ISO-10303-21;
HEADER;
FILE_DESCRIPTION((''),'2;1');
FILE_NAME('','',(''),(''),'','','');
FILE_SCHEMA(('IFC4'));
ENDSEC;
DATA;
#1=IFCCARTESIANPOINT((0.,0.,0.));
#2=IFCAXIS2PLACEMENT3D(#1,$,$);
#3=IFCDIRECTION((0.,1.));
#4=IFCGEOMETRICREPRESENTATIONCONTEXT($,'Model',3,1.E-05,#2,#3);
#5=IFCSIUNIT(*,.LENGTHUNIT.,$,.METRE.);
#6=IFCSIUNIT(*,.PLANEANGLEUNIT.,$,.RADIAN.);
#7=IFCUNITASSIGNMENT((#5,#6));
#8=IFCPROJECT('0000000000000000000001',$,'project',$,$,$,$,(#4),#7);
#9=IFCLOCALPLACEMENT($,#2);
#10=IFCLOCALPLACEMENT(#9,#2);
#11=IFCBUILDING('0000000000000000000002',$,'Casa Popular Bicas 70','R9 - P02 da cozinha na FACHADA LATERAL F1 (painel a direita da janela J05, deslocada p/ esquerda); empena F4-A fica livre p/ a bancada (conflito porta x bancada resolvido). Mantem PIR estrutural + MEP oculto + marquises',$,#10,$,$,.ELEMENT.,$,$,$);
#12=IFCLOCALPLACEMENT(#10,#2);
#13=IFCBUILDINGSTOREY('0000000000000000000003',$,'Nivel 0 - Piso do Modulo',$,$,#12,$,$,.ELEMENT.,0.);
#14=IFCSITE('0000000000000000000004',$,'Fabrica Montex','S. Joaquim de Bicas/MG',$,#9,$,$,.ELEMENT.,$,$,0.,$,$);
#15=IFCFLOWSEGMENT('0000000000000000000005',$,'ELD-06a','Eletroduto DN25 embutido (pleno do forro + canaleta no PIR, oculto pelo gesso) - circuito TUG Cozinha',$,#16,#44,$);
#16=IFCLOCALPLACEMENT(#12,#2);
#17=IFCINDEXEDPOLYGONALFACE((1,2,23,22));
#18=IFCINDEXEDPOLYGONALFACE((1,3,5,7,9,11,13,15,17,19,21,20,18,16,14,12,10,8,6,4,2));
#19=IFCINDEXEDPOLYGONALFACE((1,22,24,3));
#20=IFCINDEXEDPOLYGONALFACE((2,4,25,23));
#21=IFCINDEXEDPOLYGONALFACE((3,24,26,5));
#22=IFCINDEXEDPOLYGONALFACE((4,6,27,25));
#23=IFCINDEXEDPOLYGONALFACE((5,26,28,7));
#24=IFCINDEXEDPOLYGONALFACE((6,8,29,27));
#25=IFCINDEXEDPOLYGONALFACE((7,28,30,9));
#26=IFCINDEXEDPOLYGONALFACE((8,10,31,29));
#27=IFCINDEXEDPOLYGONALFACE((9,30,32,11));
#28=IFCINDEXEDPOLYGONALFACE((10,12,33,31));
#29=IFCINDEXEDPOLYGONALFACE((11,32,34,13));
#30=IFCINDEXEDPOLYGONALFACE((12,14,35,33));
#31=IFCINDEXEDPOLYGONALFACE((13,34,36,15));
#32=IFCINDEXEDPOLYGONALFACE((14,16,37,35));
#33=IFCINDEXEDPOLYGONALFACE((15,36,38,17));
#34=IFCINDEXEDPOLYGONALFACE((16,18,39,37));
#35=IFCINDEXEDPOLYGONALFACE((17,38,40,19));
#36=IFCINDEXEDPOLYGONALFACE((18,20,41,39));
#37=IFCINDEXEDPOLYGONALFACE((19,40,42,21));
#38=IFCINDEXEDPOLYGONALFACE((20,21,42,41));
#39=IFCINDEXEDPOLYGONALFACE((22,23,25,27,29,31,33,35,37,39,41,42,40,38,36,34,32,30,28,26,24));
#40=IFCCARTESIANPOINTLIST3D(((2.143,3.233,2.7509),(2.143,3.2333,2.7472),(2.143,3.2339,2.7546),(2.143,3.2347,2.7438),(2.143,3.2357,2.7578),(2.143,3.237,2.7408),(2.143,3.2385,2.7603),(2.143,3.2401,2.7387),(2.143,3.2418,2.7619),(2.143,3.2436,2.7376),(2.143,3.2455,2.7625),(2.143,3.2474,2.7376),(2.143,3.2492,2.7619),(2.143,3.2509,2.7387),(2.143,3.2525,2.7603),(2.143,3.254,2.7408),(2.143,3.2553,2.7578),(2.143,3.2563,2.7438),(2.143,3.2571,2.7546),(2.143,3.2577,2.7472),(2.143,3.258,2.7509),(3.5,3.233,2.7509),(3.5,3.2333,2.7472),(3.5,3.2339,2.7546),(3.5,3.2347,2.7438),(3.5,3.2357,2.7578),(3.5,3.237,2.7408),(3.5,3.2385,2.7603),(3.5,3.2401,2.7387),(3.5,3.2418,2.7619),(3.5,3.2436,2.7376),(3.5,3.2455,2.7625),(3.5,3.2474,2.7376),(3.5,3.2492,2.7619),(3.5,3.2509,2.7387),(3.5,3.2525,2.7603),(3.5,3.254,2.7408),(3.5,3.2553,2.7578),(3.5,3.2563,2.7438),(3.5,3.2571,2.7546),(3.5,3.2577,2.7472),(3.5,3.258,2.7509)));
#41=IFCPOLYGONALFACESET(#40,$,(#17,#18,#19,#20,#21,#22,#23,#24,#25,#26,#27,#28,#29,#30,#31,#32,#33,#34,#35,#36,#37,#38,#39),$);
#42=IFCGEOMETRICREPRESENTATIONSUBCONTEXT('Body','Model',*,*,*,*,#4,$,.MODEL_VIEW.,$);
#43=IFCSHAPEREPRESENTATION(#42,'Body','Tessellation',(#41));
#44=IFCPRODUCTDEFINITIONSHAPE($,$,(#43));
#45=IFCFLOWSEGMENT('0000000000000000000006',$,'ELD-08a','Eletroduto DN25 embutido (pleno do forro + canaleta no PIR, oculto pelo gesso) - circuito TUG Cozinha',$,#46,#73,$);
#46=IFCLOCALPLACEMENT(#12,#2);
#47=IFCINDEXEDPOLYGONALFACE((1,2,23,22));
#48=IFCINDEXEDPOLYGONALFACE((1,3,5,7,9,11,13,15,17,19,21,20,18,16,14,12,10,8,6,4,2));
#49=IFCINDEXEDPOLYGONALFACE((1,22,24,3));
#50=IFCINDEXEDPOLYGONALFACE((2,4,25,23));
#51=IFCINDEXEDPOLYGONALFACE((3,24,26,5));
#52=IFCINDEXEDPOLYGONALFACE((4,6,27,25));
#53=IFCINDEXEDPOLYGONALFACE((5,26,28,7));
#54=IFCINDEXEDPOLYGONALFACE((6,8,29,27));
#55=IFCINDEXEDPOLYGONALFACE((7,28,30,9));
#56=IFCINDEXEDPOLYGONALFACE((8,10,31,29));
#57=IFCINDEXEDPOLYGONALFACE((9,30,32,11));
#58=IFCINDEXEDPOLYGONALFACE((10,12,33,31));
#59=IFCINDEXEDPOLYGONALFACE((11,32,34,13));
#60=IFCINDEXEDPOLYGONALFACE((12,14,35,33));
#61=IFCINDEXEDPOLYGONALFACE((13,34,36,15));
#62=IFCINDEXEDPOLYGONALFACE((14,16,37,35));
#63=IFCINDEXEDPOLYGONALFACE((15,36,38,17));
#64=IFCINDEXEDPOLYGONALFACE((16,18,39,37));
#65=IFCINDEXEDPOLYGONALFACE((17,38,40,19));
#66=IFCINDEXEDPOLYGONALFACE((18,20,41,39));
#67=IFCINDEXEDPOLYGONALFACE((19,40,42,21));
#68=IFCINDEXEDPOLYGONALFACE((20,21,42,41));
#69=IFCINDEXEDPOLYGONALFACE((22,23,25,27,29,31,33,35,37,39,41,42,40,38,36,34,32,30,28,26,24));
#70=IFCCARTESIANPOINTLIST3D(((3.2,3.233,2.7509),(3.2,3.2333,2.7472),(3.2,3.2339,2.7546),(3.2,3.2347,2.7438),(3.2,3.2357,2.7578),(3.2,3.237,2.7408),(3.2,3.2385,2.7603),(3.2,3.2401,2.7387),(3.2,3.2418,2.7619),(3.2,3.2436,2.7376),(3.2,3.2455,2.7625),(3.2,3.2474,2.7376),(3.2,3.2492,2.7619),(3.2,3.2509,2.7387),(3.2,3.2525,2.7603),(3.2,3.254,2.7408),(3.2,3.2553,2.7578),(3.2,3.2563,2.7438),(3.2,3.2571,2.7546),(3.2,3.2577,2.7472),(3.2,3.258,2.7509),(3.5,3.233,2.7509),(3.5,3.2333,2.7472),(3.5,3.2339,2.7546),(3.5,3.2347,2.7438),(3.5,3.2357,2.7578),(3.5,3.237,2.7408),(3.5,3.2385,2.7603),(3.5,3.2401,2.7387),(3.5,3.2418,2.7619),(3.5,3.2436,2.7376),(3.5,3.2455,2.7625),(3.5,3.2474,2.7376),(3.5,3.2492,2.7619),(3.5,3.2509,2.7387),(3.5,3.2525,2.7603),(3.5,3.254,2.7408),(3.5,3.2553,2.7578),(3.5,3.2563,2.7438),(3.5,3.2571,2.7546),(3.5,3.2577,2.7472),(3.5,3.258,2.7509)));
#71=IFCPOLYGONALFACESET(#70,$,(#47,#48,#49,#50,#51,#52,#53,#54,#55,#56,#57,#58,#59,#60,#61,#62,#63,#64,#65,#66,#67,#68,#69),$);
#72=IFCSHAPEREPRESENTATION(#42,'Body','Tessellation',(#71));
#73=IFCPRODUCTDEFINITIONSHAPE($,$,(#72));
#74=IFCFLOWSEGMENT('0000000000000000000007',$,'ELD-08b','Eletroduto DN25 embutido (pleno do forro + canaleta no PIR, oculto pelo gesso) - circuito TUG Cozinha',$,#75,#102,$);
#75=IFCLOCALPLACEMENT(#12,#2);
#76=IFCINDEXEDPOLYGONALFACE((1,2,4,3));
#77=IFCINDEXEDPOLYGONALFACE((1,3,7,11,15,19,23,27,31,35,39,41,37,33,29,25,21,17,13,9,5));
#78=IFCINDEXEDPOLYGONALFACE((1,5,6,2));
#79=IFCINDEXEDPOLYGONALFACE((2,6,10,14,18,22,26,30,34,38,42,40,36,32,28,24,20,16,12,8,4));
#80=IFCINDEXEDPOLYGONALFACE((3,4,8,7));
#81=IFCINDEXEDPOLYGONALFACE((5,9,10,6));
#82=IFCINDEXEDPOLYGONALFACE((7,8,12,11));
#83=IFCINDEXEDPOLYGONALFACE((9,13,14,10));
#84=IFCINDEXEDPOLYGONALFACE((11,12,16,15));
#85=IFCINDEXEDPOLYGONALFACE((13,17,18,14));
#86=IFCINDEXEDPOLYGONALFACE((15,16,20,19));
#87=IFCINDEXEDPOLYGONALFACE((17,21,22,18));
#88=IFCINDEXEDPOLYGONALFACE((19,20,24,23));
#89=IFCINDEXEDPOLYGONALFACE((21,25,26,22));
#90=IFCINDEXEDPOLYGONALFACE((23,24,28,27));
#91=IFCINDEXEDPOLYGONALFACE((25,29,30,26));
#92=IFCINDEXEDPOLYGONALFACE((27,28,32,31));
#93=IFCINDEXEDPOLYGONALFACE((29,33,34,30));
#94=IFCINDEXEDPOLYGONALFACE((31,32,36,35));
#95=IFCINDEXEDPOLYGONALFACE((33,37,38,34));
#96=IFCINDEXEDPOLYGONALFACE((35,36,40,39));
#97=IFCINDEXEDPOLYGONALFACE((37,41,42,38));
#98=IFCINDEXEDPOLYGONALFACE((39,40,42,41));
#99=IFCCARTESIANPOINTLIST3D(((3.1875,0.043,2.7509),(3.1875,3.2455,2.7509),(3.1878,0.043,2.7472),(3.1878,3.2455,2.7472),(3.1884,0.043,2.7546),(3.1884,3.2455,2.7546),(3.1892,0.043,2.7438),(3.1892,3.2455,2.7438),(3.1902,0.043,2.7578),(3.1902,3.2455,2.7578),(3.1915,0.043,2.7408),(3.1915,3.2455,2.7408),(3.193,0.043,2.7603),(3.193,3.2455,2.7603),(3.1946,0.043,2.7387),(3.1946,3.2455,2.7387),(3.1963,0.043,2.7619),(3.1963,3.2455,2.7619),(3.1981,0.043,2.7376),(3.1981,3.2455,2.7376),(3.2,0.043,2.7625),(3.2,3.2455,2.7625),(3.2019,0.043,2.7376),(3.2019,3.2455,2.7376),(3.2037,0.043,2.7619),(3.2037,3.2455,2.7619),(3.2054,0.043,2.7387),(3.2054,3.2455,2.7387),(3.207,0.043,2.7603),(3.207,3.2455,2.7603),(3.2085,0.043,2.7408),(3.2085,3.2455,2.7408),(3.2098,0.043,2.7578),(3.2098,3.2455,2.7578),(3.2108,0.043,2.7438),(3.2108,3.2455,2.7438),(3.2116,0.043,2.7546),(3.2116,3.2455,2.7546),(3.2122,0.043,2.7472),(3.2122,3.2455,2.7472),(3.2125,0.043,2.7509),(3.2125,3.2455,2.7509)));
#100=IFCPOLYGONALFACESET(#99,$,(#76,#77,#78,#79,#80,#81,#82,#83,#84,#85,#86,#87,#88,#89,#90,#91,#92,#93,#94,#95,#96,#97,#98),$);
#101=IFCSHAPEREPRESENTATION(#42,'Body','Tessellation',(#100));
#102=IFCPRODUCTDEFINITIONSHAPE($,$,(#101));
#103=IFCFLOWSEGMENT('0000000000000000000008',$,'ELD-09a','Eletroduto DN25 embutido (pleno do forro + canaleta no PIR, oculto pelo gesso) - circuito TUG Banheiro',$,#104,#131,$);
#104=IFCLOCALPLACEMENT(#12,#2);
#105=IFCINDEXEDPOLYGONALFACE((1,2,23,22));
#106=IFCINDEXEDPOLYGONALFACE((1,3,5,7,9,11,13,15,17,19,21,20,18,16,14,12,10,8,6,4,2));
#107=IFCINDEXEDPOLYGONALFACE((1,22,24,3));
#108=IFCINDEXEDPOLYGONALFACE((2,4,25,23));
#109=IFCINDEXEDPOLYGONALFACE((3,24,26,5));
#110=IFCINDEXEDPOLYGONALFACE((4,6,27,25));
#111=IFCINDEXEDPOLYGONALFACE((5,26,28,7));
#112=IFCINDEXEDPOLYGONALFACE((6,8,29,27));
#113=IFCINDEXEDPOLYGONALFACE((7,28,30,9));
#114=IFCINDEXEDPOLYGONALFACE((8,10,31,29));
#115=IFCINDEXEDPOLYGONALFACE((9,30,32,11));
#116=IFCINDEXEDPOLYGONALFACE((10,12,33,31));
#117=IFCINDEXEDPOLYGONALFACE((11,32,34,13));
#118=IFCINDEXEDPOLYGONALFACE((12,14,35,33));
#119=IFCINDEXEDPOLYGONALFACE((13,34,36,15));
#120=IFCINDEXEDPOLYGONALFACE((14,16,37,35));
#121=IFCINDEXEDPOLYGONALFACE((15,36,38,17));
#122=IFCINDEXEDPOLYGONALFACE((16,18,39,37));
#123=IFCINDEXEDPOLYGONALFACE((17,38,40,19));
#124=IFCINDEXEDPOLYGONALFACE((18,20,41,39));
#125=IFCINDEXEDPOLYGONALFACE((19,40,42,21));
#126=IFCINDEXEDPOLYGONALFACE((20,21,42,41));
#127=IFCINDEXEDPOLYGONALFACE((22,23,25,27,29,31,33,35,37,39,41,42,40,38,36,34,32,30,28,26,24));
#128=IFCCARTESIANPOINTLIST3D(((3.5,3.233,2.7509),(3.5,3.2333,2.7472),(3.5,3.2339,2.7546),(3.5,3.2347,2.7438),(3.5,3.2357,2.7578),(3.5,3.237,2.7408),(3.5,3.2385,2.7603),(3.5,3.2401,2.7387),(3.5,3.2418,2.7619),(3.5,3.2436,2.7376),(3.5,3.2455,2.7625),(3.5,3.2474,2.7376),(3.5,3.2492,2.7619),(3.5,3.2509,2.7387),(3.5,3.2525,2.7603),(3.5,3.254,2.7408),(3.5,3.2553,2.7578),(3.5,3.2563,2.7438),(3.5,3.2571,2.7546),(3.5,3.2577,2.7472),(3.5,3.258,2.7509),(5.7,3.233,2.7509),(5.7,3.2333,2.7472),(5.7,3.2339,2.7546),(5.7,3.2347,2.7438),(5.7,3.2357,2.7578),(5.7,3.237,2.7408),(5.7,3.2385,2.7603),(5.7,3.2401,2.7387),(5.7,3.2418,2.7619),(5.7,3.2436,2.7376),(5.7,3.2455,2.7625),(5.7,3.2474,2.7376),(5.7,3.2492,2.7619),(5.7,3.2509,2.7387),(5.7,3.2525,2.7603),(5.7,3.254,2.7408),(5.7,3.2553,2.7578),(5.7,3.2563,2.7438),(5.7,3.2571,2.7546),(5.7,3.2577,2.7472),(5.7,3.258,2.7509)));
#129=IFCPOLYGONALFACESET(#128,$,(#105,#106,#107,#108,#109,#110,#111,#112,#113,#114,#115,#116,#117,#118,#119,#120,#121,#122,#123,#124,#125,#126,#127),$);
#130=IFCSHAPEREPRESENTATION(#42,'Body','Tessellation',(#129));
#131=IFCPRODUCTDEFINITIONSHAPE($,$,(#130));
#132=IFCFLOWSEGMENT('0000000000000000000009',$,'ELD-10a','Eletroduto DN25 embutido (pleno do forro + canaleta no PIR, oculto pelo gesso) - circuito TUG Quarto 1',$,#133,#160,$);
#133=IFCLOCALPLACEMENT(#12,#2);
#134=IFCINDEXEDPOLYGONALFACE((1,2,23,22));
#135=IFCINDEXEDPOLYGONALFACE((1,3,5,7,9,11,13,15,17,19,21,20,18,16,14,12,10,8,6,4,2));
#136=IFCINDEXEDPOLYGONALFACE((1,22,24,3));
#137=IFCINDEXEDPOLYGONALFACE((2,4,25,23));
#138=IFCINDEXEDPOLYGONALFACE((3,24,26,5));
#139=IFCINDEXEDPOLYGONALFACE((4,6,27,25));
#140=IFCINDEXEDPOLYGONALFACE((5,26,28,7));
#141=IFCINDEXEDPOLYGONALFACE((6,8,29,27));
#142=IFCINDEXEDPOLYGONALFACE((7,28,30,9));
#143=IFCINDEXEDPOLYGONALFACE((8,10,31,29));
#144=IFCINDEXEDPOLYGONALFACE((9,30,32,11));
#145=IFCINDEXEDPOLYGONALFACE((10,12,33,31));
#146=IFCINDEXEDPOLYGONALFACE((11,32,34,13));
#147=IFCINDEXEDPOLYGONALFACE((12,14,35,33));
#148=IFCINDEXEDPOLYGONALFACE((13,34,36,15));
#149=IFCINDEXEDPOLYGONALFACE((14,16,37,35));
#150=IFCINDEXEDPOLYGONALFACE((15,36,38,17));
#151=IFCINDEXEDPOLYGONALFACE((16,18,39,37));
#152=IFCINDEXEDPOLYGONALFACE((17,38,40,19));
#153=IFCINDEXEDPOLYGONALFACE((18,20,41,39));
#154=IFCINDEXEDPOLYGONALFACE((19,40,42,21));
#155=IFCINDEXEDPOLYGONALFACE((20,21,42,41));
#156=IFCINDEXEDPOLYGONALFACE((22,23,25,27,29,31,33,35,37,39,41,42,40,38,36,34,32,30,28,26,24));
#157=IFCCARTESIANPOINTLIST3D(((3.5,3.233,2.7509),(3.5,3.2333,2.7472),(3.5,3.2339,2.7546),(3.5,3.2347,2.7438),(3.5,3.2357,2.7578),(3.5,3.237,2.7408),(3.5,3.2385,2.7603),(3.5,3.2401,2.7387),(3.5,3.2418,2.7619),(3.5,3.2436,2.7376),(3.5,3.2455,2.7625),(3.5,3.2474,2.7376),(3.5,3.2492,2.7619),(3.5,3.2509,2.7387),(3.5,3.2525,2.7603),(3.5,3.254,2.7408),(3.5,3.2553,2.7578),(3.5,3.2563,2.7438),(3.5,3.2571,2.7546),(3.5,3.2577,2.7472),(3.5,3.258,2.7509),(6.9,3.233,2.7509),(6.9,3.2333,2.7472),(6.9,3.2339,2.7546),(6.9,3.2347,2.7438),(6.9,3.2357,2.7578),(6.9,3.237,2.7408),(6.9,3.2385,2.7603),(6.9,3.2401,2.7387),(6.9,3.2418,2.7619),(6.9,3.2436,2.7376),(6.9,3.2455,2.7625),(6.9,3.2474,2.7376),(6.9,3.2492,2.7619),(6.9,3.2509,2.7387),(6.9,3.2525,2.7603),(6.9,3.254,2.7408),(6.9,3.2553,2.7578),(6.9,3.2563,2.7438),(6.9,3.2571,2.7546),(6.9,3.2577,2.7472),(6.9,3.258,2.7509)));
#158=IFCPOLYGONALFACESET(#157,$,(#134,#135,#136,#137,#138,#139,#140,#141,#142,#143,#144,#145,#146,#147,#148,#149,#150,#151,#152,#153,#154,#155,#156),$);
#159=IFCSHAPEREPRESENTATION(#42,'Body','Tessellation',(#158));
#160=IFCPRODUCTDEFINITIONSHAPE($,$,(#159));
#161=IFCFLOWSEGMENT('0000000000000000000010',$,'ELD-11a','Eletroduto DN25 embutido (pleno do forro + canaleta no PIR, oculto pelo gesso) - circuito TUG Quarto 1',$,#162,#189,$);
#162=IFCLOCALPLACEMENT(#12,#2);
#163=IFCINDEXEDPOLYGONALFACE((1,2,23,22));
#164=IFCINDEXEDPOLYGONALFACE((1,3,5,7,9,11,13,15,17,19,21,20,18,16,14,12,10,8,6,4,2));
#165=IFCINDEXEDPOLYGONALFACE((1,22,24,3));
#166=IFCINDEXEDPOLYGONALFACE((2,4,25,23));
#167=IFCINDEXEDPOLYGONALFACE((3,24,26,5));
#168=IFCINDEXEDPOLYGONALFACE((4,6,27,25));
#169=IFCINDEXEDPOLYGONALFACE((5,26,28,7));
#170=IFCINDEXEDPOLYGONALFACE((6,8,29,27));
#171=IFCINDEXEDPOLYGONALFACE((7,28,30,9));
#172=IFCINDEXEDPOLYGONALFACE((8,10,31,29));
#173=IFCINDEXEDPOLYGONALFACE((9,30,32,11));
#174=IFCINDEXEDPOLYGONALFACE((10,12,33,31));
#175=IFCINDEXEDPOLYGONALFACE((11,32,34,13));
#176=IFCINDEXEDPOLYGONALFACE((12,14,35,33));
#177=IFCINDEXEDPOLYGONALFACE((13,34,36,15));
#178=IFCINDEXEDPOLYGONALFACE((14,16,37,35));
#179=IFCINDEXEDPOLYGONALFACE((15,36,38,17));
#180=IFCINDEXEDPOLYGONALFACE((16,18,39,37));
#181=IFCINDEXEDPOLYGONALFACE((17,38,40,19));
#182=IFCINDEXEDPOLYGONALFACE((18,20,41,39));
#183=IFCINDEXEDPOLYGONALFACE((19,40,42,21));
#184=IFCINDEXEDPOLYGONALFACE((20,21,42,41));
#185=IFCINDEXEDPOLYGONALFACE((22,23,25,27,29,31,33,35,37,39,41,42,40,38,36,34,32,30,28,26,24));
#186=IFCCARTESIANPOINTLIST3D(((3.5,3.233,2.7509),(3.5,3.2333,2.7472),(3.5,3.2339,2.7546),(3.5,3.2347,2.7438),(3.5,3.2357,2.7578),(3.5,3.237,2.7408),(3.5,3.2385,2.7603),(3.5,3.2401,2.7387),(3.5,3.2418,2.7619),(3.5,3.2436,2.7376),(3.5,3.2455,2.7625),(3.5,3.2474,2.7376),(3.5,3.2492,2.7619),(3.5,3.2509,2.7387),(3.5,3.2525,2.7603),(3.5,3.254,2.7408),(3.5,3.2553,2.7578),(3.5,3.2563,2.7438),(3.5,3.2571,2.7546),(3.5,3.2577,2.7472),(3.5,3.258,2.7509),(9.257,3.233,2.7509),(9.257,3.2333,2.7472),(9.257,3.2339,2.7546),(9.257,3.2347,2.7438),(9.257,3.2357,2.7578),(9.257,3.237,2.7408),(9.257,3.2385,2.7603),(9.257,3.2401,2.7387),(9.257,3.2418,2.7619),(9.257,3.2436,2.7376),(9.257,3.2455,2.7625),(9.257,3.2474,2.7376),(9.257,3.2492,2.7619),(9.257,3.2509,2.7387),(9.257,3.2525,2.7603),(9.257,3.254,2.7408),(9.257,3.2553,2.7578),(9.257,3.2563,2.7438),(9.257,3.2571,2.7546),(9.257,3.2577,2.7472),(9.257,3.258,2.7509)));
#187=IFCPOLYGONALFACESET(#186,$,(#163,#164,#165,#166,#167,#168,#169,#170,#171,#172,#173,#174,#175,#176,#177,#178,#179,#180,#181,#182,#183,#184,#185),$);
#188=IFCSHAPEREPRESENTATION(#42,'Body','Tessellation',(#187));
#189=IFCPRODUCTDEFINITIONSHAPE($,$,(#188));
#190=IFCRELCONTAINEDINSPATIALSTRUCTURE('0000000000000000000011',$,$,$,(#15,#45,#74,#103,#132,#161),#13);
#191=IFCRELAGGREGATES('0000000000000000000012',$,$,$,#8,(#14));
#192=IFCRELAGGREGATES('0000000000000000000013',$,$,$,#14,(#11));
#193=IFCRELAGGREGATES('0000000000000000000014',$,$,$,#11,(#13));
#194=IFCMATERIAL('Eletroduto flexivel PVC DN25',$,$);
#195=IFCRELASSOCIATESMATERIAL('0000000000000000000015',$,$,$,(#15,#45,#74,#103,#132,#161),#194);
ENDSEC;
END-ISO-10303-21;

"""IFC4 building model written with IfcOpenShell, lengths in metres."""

from ifc_helpers import new_model, si_unit, direction, frame, origin, origin_2d, place, context, subcontext, project, spatial, circle, extrude, material, element, save


model = new_model("IFC4")

# Units and contexts
model_context = context("Model", 3, precision=1e-05, world=origin(), true_north=direction((0.0, 1.0)))
body_context = subcontext(model_context, "Body", "Model", "MODEL_VIEW")
ifc_project = project(units=[si_unit("LENGTHUNIT", "METRE"), si_unit("PLANEANGLEUNIT", "RADIAN")], contexts=[model_context])

# Site, building, storey
site_placement = place(None, origin())
site = spatial("IfcSite", under=ifc_project, at=site_placement, Name="Fabrica Montex", Description="S. Joaquim de Bicas/MG", CompositionType="ELEMENT", RefElevation=0.0)
building_placement = place(site_placement, origin())
building = spatial("IfcBuilding", under=site, at=building_placement, Name="Casa Popular Bicas 70", Description="R9 - P02 da cozinha na FACHADA LATERAL F1 (painel a direita da janela J05, deslocada p/ esquerda); empena F4-A fica livre p/ a bancada (conflito porta x bancada resolvido). Mantem PIR estrutural + MEP oculto + marquises", CompositionType="ELEMENT")
storey_placement = place(building_placement, origin())
storey = spatial("IfcBuildingStorey", under=building, at=storey_placement, Name="Nivel 0 - Piso do Modulo", CompositionType="ELEMENT", Elevation=0.0)

# Flow segments
ifc_material_1 = material(Name="Eletroduto flexivel PVC DN25")
for number, where, z_axis, x_axis, name in (
    (1, (3.5, 3.2455, 2.75), (-1.0, 0.0, 0.0), (0.0, 0.0, 1.0), "ELD-06a"),
):
    element("IfcFlowSegment", number, at=place(storey_placement, frame(where, z_axis=z_axis, x_axis=x_axis)), inside=storey, material=ifc_material_1, Name=name, Description="Eletroduto DN25 embutido (pleno do forro + canaleta no PIR, oculto pelo gesso) - circuito TUG Cozinha", context=body_context, shape_type="SweptSolid", body=[
        extrude(circle(Radius=0.0125, at=origin_2d()), origin(), (0.0, 0.0, 1.0), 1.357),
    ])
flow_segment_1_placement = place(storey_placement, frame((3.5, 3.2455, 2.75), z_axis=(-1.0, 0.0, 0.0), x_axis=(0.0, 0.0, 1.0)))
element("IfcFlowSegment", 2, at=flow_segment_1_placement, inside=storey, material=ifc_material_1, Name="ELD-08a", Description="Eletroduto DN25 embutido (pleno do forro + canaleta no PIR, oculto pelo gesso) - circuito TUG Cozinha", context=body_context, shape_type="SweptSolid", body=[
    extrude(circle(Radius=0.0125, at=origin_2d()), origin(), (0.0, 0.0, 1.0), 0.3),
])
flow_segment_2_placement = place(storey_placement, frame((3.2, 3.2455, 2.75), z_axis=(0.0, -1.0, 0.0), x_axis=(0.0, 0.0, 1.0)))
element("IfcFlowSegment", 3, at=flow_segment_2_placement, inside=storey, material=ifc_material_1, Name="ELD-08b", Description="Eletroduto DN25 embutido (pleno do forro + canaleta no PIR, oculto pelo gesso) - circuito TUG Cozinha", context=body_context, shape_type="SweptSolid", body=[
    extrude(circle(Radius=0.0125, at=origin_2d()), origin(), (0.0, 0.0, 1.0), 3.2025),
])
flow_segment_3_placement = place(storey_placement, frame((3.5, 3.2455, 2.75), z_axis=(1.0, 0.0, 0.0), x_axis=(0.0, 0.0, 1.0)))
element("IfcFlowSegment", 4, at=flow_segment_3_placement, inside=storey, material=ifc_material_1, Name="ELD-09a", Description="Eletroduto DN25 embutido (pleno do forro + canaleta no PIR, oculto pelo gesso) - circuito TUG Banheiro", context=body_context, shape_type="SweptSolid", body=[
    extrude(circle(Radius=0.0125, at=origin_2d()), origin(), (0.0, 0.0, 1.0), 2.2),
])
flow_segment_4_placement = place(storey_placement, frame((3.5, 3.2455, 2.75), z_axis=(1.0, 0.0, 0.0), x_axis=(0.0, 0.0, 1.0)))
element("IfcFlowSegment", 5, at=flow_segment_4_placement, inside=storey, material=ifc_material_1, Name="ELD-10a", Description="Eletroduto DN25 embutido (pleno do forro + canaleta no PIR, oculto pelo gesso) - circuito TUG Quarto 1", context=body_context, shape_type="SweptSolid", body=[
    extrude(circle(Radius=0.0125, at=origin_2d()), origin(), (0.0, 0.0, 1.0), 3.4),
])
flow_segment_5_placement = place(storey_placement, frame((3.5, 3.2455, 2.75), z_axis=(1.0, 0.0, 0.0), x_axis=(0.0, 0.0, 1.0)))
element("IfcFlowSegment", 6, at=flow_segment_5_placement, inside=storey, material=ifc_material_1, Name="ELD-11a", Description="Eletroduto DN25 embutido (pleno do forro + canaleta no PIR, oculto pelo gesso) - circuito TUG Quarto 1", context=body_context, shape_type="SweptSolid", body=[
    extrude(circle(Radius=0.0125, at=origin_2d()), origin(), (0.0, 0.0, 1.0), 5.757),
])

save(model, "model.ifc")
